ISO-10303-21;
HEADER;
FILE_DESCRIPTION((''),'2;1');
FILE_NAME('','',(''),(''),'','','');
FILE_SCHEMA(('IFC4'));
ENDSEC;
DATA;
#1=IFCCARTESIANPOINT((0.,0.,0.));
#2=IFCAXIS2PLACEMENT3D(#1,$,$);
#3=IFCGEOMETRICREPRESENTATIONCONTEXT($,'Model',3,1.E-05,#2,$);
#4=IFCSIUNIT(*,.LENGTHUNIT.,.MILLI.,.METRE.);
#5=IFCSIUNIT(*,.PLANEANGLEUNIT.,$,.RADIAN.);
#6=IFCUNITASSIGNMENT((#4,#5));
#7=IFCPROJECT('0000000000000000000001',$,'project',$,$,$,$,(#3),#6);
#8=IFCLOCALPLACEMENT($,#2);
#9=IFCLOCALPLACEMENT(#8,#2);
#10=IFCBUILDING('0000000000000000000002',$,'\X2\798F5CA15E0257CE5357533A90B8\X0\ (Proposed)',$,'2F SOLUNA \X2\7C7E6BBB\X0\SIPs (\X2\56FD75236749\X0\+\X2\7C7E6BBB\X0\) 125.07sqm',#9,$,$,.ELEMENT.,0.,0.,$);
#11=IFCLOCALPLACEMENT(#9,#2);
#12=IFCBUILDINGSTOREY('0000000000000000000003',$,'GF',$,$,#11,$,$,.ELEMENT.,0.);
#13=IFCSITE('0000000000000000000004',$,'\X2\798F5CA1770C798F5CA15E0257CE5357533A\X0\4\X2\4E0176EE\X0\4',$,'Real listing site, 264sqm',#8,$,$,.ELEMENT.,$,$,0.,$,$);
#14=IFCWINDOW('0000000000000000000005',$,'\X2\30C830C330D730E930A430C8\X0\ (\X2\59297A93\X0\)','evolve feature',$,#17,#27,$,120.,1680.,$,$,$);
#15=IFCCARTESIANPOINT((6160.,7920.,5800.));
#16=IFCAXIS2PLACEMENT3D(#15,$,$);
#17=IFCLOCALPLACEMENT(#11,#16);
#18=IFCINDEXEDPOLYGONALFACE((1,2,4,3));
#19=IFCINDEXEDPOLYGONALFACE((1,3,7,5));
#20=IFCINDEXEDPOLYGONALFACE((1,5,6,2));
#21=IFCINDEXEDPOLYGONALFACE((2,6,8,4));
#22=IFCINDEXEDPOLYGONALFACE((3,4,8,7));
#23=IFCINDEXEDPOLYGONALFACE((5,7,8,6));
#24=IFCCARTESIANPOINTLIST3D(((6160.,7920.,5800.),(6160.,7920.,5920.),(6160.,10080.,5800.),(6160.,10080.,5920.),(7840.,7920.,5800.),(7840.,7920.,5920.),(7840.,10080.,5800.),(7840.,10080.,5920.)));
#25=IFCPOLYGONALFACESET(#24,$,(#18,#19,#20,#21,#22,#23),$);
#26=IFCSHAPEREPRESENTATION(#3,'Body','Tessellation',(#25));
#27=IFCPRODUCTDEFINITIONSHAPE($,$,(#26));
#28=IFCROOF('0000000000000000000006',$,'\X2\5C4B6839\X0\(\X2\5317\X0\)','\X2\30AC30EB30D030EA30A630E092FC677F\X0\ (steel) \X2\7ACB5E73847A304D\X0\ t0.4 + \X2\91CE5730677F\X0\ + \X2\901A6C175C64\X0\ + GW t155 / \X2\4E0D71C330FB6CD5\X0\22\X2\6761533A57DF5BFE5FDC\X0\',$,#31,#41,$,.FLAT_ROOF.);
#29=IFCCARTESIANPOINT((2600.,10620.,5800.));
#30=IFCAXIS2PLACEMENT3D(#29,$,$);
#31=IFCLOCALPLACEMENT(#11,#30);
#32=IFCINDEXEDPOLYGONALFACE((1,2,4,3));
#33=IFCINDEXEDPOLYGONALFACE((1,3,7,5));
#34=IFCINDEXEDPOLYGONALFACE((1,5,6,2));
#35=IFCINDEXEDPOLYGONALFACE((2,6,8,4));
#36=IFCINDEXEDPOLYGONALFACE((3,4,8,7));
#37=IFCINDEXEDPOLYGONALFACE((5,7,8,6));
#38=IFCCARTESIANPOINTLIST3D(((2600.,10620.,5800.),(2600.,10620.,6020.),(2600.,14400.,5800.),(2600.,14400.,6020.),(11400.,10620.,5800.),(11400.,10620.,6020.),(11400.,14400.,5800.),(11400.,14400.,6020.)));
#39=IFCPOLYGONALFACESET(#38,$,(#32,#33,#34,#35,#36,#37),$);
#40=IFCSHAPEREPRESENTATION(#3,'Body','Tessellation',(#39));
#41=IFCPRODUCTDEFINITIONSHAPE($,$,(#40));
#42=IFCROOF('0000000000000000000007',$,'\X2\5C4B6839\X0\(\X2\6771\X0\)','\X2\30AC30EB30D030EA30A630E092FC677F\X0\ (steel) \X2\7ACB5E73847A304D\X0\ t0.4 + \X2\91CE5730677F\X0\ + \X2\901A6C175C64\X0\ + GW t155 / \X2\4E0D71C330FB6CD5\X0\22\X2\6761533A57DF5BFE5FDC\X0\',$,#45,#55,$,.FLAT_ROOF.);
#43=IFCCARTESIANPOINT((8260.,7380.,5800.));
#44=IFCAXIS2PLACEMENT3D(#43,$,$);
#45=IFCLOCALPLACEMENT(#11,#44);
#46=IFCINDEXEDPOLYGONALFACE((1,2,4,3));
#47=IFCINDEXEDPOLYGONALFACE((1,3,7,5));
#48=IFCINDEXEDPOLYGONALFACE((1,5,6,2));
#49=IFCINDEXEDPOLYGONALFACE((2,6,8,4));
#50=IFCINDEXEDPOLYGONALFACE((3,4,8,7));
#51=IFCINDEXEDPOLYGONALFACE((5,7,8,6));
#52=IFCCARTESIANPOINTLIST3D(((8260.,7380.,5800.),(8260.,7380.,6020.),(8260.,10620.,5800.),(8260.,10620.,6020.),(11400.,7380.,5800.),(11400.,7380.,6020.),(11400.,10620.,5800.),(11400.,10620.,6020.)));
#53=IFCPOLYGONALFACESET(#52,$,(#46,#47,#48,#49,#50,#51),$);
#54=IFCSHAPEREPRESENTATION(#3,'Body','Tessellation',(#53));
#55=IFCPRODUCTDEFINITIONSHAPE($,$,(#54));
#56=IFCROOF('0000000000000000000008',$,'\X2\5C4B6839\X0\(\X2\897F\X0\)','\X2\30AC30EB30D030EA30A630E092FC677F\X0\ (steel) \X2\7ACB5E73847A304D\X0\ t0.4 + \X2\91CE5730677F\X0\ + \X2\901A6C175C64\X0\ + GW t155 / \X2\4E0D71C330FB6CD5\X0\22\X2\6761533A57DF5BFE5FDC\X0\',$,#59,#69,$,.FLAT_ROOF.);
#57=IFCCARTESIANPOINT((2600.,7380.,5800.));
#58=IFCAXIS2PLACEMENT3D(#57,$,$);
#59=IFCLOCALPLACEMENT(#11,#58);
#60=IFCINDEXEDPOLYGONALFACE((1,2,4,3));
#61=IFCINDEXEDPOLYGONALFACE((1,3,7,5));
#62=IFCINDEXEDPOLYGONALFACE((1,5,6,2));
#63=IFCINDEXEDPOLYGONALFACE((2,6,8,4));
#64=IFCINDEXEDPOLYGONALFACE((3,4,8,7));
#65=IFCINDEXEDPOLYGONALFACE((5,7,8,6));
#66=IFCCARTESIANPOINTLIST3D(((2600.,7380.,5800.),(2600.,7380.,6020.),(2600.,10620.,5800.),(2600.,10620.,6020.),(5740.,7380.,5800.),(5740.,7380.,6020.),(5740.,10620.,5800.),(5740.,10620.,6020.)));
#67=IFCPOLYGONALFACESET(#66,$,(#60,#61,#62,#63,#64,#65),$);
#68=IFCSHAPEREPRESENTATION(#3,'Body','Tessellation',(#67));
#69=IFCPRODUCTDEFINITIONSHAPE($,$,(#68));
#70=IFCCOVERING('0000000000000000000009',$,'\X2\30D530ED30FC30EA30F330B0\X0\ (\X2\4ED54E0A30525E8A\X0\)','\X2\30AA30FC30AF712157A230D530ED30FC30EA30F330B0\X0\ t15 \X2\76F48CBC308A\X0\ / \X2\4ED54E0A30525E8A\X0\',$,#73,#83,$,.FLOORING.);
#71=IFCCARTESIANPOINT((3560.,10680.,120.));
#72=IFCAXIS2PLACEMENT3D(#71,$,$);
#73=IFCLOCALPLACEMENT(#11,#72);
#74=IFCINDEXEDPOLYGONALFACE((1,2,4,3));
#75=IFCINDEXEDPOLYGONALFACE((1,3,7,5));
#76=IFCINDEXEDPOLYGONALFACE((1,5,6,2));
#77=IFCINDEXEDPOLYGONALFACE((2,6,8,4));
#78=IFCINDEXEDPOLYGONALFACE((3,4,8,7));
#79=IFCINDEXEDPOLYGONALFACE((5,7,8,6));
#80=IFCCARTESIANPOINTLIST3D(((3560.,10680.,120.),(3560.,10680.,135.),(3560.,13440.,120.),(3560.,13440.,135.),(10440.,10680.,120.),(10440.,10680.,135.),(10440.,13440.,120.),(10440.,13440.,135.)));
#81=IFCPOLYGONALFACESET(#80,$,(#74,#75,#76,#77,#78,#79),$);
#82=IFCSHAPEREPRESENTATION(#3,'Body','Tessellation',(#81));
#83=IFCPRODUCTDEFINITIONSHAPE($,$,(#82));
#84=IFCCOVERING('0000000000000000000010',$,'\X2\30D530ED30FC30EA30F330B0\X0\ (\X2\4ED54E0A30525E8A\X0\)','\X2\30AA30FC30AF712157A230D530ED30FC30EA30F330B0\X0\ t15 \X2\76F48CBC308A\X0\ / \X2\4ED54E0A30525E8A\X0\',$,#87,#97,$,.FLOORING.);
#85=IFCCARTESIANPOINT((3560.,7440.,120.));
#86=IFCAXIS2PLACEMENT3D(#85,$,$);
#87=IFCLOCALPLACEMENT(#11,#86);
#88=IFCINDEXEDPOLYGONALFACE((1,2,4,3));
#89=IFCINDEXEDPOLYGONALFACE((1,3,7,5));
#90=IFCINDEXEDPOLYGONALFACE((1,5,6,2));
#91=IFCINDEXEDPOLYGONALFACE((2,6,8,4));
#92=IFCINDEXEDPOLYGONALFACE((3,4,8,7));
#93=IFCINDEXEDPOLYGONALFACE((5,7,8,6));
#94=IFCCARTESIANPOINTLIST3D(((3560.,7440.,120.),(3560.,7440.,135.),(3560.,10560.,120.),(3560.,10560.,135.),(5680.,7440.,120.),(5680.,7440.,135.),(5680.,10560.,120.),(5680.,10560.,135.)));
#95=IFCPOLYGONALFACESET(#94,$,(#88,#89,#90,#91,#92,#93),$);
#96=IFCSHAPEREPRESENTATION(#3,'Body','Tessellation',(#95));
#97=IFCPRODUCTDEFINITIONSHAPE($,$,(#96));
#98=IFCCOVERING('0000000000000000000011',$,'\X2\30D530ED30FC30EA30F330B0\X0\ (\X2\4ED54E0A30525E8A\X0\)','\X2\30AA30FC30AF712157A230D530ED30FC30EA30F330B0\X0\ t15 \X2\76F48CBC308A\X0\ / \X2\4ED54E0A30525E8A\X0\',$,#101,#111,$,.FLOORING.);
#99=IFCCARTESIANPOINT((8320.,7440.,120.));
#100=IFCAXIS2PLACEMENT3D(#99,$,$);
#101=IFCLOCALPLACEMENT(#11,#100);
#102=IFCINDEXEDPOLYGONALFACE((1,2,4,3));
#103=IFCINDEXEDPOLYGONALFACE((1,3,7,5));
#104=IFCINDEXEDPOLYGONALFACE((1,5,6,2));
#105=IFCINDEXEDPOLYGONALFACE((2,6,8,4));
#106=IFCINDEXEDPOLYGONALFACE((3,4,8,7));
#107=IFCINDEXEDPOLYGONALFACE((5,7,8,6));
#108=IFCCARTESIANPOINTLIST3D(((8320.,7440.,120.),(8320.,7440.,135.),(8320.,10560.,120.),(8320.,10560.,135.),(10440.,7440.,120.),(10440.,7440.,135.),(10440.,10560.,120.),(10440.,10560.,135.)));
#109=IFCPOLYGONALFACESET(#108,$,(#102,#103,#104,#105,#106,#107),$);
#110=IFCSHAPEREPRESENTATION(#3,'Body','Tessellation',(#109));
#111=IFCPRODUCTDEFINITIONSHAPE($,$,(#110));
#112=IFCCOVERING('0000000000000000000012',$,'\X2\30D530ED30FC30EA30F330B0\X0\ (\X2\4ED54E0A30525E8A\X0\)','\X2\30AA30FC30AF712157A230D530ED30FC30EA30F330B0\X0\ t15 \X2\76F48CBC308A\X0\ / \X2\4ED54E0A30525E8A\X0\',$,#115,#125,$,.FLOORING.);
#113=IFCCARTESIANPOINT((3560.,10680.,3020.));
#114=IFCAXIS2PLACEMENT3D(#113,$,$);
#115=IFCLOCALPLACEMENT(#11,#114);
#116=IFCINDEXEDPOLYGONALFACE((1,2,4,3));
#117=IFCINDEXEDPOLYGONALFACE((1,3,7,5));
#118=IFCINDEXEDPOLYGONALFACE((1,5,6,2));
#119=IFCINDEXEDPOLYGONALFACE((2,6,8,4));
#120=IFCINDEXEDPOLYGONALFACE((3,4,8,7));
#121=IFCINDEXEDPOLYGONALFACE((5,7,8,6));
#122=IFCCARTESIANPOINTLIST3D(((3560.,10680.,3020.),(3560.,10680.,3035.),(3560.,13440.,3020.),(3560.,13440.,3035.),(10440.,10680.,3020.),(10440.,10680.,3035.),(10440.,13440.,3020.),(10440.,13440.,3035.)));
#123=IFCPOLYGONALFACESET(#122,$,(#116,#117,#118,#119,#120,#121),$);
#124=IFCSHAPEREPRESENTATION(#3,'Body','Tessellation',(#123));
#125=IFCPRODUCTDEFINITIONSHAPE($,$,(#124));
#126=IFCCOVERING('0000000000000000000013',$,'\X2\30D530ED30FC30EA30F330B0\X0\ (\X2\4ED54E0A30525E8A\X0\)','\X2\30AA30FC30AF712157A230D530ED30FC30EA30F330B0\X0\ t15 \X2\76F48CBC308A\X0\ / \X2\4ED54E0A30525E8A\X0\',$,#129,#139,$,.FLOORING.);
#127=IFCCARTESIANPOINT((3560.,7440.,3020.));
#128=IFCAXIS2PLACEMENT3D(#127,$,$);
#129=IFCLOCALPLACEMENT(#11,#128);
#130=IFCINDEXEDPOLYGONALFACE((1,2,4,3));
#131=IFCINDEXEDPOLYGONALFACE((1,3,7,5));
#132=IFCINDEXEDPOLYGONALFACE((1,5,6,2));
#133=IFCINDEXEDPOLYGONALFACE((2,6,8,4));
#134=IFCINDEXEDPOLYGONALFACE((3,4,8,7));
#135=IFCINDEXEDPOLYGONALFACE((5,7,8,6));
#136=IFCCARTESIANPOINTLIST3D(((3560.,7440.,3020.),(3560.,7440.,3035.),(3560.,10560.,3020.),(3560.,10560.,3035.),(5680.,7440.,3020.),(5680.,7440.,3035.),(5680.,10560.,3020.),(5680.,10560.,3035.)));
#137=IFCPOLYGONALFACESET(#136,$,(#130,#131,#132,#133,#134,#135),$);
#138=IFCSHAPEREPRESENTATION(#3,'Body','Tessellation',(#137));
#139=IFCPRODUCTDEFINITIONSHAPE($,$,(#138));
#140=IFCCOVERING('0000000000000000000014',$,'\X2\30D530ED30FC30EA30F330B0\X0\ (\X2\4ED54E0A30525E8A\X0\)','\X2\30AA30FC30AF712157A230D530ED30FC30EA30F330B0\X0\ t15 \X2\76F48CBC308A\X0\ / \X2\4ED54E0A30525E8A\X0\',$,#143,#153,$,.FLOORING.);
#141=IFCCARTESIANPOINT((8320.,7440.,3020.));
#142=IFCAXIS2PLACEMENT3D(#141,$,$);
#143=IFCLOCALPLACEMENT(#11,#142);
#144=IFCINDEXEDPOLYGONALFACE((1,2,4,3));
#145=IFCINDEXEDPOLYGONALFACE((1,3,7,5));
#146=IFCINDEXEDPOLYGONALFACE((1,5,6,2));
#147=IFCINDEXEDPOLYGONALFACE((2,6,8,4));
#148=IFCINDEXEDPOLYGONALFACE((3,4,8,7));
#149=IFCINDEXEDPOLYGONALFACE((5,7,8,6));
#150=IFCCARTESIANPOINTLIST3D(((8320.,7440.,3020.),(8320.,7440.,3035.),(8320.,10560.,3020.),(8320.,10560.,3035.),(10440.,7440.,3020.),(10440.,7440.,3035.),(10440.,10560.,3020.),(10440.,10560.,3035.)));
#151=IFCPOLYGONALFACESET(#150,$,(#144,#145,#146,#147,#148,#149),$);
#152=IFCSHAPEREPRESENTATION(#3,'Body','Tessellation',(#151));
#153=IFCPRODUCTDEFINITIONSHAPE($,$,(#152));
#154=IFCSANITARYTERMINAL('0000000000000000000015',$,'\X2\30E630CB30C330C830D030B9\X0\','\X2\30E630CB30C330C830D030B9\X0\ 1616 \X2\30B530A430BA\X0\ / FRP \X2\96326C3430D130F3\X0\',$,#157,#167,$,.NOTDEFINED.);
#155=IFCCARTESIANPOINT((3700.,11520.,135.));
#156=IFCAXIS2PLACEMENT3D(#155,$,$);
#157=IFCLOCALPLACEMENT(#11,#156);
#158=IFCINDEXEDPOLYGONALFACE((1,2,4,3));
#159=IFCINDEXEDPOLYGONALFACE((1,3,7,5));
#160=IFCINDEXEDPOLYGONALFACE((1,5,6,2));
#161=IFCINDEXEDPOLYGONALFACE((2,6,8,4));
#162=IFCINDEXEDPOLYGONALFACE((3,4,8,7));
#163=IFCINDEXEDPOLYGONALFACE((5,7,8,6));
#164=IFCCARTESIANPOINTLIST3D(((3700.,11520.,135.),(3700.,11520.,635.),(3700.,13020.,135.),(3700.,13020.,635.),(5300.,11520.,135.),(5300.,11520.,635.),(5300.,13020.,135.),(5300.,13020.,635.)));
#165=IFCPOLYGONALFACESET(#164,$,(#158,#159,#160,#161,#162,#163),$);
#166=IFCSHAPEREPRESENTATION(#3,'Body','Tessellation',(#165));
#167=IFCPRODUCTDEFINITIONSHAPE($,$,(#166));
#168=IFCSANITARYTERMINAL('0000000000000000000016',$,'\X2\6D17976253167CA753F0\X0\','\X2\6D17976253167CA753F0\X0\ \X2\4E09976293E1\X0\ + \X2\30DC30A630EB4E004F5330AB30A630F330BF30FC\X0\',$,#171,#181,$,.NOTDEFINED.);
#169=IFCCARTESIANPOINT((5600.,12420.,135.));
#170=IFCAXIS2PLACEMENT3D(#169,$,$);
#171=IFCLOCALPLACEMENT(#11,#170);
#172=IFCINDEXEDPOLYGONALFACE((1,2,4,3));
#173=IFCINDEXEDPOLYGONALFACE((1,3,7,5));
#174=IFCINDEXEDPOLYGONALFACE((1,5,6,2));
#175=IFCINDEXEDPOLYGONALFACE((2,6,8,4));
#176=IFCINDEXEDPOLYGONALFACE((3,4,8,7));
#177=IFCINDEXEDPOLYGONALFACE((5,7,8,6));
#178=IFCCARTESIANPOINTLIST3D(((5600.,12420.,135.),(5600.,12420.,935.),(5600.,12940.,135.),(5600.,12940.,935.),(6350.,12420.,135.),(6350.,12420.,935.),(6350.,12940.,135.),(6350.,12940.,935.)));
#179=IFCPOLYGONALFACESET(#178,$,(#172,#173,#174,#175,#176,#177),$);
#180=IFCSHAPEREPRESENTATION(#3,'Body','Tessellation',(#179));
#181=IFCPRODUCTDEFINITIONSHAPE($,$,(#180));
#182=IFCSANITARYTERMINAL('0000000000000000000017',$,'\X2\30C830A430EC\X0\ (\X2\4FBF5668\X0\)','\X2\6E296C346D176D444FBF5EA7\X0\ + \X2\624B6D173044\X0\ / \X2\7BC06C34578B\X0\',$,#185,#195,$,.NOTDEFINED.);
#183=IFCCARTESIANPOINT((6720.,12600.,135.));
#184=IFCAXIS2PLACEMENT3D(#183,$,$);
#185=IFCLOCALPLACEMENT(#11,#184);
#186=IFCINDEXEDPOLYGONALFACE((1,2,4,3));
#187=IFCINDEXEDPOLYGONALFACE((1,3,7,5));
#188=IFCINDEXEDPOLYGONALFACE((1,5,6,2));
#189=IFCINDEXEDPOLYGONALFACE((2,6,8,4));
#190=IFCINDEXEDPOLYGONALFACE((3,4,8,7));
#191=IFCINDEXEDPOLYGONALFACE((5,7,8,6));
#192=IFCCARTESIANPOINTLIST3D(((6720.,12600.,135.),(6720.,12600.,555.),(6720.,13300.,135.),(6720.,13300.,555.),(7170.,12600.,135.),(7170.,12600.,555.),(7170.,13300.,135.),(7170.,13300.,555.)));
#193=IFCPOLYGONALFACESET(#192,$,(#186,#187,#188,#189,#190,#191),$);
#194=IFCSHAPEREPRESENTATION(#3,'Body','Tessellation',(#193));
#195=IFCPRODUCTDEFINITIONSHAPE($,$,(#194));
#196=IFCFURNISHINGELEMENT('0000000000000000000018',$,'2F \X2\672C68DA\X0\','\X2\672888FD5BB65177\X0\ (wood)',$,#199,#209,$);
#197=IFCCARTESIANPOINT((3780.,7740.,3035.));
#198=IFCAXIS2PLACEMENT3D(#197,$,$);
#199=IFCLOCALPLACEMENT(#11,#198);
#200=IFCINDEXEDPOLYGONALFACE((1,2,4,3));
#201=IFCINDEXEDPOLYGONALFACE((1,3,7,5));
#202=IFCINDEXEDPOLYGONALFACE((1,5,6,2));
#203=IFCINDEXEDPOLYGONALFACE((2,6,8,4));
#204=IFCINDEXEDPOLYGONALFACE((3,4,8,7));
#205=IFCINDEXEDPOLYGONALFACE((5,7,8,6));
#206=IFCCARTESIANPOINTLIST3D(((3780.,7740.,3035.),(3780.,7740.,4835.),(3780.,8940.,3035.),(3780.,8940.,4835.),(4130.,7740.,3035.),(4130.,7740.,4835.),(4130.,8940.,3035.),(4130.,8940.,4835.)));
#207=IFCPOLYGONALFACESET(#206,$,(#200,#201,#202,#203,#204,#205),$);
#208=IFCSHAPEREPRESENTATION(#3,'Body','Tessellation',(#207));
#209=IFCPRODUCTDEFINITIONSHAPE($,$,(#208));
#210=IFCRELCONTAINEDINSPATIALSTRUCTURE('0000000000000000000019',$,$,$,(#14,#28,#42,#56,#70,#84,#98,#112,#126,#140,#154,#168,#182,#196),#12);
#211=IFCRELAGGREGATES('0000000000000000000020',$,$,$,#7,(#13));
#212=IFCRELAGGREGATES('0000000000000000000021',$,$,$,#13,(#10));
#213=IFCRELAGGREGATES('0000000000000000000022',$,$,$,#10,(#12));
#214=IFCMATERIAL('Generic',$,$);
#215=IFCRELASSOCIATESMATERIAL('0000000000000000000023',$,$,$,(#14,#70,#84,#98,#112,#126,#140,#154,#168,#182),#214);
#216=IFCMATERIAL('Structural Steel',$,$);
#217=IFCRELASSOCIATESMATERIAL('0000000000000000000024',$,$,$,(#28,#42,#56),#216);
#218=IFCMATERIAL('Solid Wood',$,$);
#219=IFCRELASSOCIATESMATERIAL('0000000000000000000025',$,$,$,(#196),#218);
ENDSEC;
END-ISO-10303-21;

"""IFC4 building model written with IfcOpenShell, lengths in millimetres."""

from ifc_helpers import new_model, si_unit, frame, frame_2d, origin, place, context, project, spatial, rectangle, extrude, material, element, save


model = new_model("IFC4")

# Units and contexts
model_context = context("Model", 3, precision=1e-05, world=origin())
ifc_project = project(units=[si_unit("LENGTHUNIT", "METRE", prefix="MILLI"), si_unit("PLANEANGLEUNIT", "RADIAN")], contexts=[model_context])

# Site, building, storey
site_placement = place(None, origin())
site = spatial("IfcSite", under=ifc_project, at=site_placement, Name="福岡県福岡市城南区4丁目4", ObjectType="Real listing site, 264sqm", CompositionType="ELEMENT", RefElevation=0.0)
building_placement = place(site_placement, origin())
building = spatial("IfcBuilding", under=site, at=building_placement, Name="福岡市城南区邸 (Proposed)", ObjectType="2F SOLUNA 籾殻SIPs (国産杉+籾殻) 125.07sqm", CompositionType="ELEMENT", ElevationOfRefHeight=0.0, ElevationOfTerrain=0.0)
storey_placement = place(building_placement, origin())
storey = spatial("IfcBuildingStorey", under=building, at=storey_placement, Name="GF", CompositionType="ELEMENT", Elevation=0.0)

# Shared definitions
ifc_material_1 = material(Name="Solid Wood")

# Window
ifc_material_2 = material(Name="Generic")
window_1_placement = place(storey_placement, frame((6160.0, 7920.0, 5800.0)))
element("IfcWindow", 1, at=window_1_placement, inside=storey, material=ifc_material_2, Name="トップライト (天窓)", Description="evolve feature", OverallHeight=120.0, OverallWidth=1680.0, context=model_context, shape_type="SweptSolid", body=[
    extrude(rectangle(XDim=1680.0, YDim=2160.0, at=frame_2d((840.0, 1080.0))), frame((6160.0, 7920.0, 5800.0)), (0.0, 0.0, 1.0), 120.0),
])

# Roofs
ifc_material_3 = material(Name="Structural Steel")
roof_1_placement = place(storey_placement, frame((2600.0, 10620.0, 5800.0)))
element("IfcRoof", 2, at=roof_1_placement, inside=storey, material=ifc_material_3, Name="屋根(北)", Description="ガルバリウム鋼板 (steel) 立平葺き t0.4 + 野地板 + 通気層 + GW t155 / 不燃・法22条区域対応", PredefinedType="FLAT_ROOF", context=model_context, shape_type="SweptSolid", body=[
    extrude(rectangle(XDim=8800.0, YDim=3780.0, at=frame_2d((4400.0, 1890.0))), frame((2600.0, 10620.0, 5800.0)), (0.0, 0.0, 1.0), 220.0),
])
roof_2_placement = place(storey_placement, frame((8260.0, 7380.0, 5800.0)))
element("IfcRoof", 3, at=roof_2_placement, inside=storey, material=ifc_material_3, Name="屋根(東)", Description="ガルバリウム鋼板 (steel) 立平葺き t0.4 + 野地板 + 通気層 + GW t155 / 不燃・法22条区域対応", PredefinedType="FLAT_ROOF", context=model_context, shape_type="SweptSolid", body=[
    extrude(rectangle(XDim=3140.0, YDim=3240.0, at=frame_2d((1570.0, 1620.0))), frame((8260.0, 7380.0, 5800.0)), (0.0, 0.0, 1.0), 220.0),
])
roof_3_placement = place(storey_placement, frame((2600.0, 7380.0, 5800.0)))
element("IfcRoof", 4, at=roof_3_placement, inside=storey, material=ifc_material_3, Name="屋根(西)", Description="ガルバリウム鋼板 (steel) 立平葺き t0.4 + 野地板 + 通気層 + GW t155 / 不燃・法22条区域対応", PredefinedType="FLAT_ROOF", context=model_context, shape_type="SweptSolid", body=[
    extrude(rectangle(XDim=3140.0, YDim=3240.0, at=frame_2d((1570.0, 1620.0))), frame((2600.0, 7380.0, 5800.0)), (0.0, 0.0, 1.0), 220.0),
])

# Coverings
covering_1_placement = place(storey_placement, frame((3560.0, 10680.0, 120.0)))
element("IfcCovering", 5, at=covering_1_placement, inside=storey, material=ifc_material_2, Name="フローリング (仕上げ床)", Description="オーク無垢フローリング t15 直貼り / 仕上げ床", PredefinedType="FLOORING", context=model_context, shape_type="SweptSolid", body=[
    extrude(rectangle(XDim=6880.0, YDim=2760.0, at=frame_2d((3440.0, 1380.0))), frame((3560.0, 10680.0, 120.0)), (0.0, 0.0, 1.0), 15.0),
])
covering_2_placement = place(storey_placement, frame((3560.0, 7440.0, 120.0)))
element("IfcCovering", 6, at=covering_2_placement, inside=storey, material=ifc_material_2, Name="フローリング (仕上げ床)", Description="オーク無垢フローリング t15 直貼り / 仕上げ床", PredefinedType="FLOORING", context=model_context, shape_type="SweptSolid", body=[
    extrude(rectangle(XDim=2120.0, YDim=3120.0, at=frame_2d((1060.0, 1560.0))), frame((3560.0, 7440.0, 120.0)), (0.0, 0.0, 1.0), 15.0),
])
covering_3_placement = place(storey_placement, frame((8320.0, 7440.0, 120.0)))
element("IfcCovering", 7, at=covering_3_placement, inside=storey, material=ifc_material_2, Name="フローリング (仕上げ床)", Description="オーク無垢フローリング t15 直貼り / 仕上げ床", PredefinedType="FLOORING", context=model_context, shape_type="SweptSolid", body=[
    extrude(rectangle(XDim=2120.0, YDim=3120.0, at=frame_2d((1060.0, 1560.0))), frame((8320.0, 7440.0, 120.0)), (0.0, 0.0, 1.0), 15.0),
])
covering_4_placement = place(storey_placement, frame((3560.0, 10680.0, 3020.0)))
element("IfcCovering", 8, at=covering_4_placement, inside=storey, material=ifc_material_2, Name="フローリング (仕上げ床)", Description="オーク無垢フローリング t15 直貼り / 仕上げ床", PredefinedType="FLOORING", context=model_context, shape_type="SweptSolid", body=[
    extrude(rectangle(XDim=6880.0, YDim=2760.0, at=frame_2d((3440.0, 1380.0))), frame((3560.0, 10680.0, 3020.0)), (0.0, 0.0, 1.0), 15.0),
])
covering_5_placement = place(storey_placement, frame((3560.0, 7440.0, 3020.0)))
element("IfcCovering", 9, at=covering_5_placement, inside=storey, material=ifc_material_2, Name="フローリング (仕上げ床)", Description="オーク無垢フローリング t15 直貼り / 仕上げ床", PredefinedType="FLOORING", context=model_context, shape_type="SweptSolid", body=[
    extrude(rectangle(XDim=2120.0, YDim=3120.0, at=frame_2d((1060.0, 1560.0))), frame((3560.0, 7440.0, 3020.0)), (0.0, 0.0, 1.0), 15.0),
])
covering_6_placement = place(storey_placement, frame((8320.0, 7440.0, 3020.0)))
element("IfcCovering", 10, at=covering_6_placement, inside=storey, material=ifc_material_2, Name="フローリング (仕上げ床)", Description="オーク無垢フローリング t15 直貼り / 仕上げ床", PredefinedType="FLOORING", context=model_context, shape_type="SweptSolid", body=[
    extrude(rectangle(XDim=2120.0, YDim=3120.0, at=frame_2d((1060.0, 1560.0))), frame((8320.0, 7440.0, 3020.0)), (0.0, 0.0, 1.0), 15.0),
])

# Sanitary terminals
sanitary_terminal_1_placement = place(storey_placement, frame((3700.0, 11520.0, 135.0)))
element("IfcSanitaryTerminal", 11, at=sanitary_terminal_1_placement, inside=storey, material=ifc_material_2, Name="ユニットバス", Description="ユニットバス 1616 サイズ / FRP 防水パン", PredefinedType="NOTDEFINED", context=model_context, shape_type="SweptSolid", body=[
    extrude(rectangle(XDim=1600.0, YDim=1500.0, at=frame_2d((800.0, 750.0))), frame((3700.0, 11520.0, 135.0)), (0.0, 0.0, 1.0), 500.0),
])
sanitary_terminal_2_placement = place(storey_placement, frame((5600.0, 12420.0, 135.0)))
element("IfcSanitaryTerminal", 12, at=sanitary_terminal_2_placement, inside=storey, material=ifc_material_2, Name="洗面化粧台", Description="洗面化粧台 三面鏡 + ボウル一体カウンター", PredefinedType="NOTDEFINED", context=model_context, shape_type="SweptSolid", body=[
    extrude(rectangle(XDim=750.0, YDim=520.0, at=frame_2d((375.0, 260.0))), frame((5600.0, 12420.0, 135.0)), (0.0, 0.0, 1.0), 800.0),
])
sanitary_terminal_3_placement = place(storey_placement, frame((6720.0, 12600.0, 135.0)))
element("IfcSanitaryTerminal", 13, at=sanitary_terminal_3_placement, inside=storey, material=ifc_material_2, Name="トイレ (便器)", Description="温水洗浄便座 + 手洗い / 節水型", PredefinedType="NOTDEFINED", context=model_context, shape_type="SweptSolid", body=[
    extrude(rectangle(XDim=450.0, YDim=700.0, at=frame_2d((225.0, 350.0))), frame((6720.0, 12600.0, 135.0)), (0.0, 0.0, 1.0), 420.0),
])

# Furnishing element
furnishing_placement = place(storey_placement, frame((3780.0, 7740.0, 3035.0)))
element("IfcFurnishingElement", 14, at=furnishing_placement, inside=storey, material=ifc_material_1, Name="2F 本棚", Description="木製家具 (wood)", context=model_context, shape_type="SweptSolid", body=[
    extrude(rectangle(XDim=350.0, YDim=1200.0, at=frame_2d((175.0, 600.0))), frame((3780.0, 7740.0, 3035.0)), (0.0, 0.0, 1.0), 1800.0),
])

save(model, "model.ifc")
